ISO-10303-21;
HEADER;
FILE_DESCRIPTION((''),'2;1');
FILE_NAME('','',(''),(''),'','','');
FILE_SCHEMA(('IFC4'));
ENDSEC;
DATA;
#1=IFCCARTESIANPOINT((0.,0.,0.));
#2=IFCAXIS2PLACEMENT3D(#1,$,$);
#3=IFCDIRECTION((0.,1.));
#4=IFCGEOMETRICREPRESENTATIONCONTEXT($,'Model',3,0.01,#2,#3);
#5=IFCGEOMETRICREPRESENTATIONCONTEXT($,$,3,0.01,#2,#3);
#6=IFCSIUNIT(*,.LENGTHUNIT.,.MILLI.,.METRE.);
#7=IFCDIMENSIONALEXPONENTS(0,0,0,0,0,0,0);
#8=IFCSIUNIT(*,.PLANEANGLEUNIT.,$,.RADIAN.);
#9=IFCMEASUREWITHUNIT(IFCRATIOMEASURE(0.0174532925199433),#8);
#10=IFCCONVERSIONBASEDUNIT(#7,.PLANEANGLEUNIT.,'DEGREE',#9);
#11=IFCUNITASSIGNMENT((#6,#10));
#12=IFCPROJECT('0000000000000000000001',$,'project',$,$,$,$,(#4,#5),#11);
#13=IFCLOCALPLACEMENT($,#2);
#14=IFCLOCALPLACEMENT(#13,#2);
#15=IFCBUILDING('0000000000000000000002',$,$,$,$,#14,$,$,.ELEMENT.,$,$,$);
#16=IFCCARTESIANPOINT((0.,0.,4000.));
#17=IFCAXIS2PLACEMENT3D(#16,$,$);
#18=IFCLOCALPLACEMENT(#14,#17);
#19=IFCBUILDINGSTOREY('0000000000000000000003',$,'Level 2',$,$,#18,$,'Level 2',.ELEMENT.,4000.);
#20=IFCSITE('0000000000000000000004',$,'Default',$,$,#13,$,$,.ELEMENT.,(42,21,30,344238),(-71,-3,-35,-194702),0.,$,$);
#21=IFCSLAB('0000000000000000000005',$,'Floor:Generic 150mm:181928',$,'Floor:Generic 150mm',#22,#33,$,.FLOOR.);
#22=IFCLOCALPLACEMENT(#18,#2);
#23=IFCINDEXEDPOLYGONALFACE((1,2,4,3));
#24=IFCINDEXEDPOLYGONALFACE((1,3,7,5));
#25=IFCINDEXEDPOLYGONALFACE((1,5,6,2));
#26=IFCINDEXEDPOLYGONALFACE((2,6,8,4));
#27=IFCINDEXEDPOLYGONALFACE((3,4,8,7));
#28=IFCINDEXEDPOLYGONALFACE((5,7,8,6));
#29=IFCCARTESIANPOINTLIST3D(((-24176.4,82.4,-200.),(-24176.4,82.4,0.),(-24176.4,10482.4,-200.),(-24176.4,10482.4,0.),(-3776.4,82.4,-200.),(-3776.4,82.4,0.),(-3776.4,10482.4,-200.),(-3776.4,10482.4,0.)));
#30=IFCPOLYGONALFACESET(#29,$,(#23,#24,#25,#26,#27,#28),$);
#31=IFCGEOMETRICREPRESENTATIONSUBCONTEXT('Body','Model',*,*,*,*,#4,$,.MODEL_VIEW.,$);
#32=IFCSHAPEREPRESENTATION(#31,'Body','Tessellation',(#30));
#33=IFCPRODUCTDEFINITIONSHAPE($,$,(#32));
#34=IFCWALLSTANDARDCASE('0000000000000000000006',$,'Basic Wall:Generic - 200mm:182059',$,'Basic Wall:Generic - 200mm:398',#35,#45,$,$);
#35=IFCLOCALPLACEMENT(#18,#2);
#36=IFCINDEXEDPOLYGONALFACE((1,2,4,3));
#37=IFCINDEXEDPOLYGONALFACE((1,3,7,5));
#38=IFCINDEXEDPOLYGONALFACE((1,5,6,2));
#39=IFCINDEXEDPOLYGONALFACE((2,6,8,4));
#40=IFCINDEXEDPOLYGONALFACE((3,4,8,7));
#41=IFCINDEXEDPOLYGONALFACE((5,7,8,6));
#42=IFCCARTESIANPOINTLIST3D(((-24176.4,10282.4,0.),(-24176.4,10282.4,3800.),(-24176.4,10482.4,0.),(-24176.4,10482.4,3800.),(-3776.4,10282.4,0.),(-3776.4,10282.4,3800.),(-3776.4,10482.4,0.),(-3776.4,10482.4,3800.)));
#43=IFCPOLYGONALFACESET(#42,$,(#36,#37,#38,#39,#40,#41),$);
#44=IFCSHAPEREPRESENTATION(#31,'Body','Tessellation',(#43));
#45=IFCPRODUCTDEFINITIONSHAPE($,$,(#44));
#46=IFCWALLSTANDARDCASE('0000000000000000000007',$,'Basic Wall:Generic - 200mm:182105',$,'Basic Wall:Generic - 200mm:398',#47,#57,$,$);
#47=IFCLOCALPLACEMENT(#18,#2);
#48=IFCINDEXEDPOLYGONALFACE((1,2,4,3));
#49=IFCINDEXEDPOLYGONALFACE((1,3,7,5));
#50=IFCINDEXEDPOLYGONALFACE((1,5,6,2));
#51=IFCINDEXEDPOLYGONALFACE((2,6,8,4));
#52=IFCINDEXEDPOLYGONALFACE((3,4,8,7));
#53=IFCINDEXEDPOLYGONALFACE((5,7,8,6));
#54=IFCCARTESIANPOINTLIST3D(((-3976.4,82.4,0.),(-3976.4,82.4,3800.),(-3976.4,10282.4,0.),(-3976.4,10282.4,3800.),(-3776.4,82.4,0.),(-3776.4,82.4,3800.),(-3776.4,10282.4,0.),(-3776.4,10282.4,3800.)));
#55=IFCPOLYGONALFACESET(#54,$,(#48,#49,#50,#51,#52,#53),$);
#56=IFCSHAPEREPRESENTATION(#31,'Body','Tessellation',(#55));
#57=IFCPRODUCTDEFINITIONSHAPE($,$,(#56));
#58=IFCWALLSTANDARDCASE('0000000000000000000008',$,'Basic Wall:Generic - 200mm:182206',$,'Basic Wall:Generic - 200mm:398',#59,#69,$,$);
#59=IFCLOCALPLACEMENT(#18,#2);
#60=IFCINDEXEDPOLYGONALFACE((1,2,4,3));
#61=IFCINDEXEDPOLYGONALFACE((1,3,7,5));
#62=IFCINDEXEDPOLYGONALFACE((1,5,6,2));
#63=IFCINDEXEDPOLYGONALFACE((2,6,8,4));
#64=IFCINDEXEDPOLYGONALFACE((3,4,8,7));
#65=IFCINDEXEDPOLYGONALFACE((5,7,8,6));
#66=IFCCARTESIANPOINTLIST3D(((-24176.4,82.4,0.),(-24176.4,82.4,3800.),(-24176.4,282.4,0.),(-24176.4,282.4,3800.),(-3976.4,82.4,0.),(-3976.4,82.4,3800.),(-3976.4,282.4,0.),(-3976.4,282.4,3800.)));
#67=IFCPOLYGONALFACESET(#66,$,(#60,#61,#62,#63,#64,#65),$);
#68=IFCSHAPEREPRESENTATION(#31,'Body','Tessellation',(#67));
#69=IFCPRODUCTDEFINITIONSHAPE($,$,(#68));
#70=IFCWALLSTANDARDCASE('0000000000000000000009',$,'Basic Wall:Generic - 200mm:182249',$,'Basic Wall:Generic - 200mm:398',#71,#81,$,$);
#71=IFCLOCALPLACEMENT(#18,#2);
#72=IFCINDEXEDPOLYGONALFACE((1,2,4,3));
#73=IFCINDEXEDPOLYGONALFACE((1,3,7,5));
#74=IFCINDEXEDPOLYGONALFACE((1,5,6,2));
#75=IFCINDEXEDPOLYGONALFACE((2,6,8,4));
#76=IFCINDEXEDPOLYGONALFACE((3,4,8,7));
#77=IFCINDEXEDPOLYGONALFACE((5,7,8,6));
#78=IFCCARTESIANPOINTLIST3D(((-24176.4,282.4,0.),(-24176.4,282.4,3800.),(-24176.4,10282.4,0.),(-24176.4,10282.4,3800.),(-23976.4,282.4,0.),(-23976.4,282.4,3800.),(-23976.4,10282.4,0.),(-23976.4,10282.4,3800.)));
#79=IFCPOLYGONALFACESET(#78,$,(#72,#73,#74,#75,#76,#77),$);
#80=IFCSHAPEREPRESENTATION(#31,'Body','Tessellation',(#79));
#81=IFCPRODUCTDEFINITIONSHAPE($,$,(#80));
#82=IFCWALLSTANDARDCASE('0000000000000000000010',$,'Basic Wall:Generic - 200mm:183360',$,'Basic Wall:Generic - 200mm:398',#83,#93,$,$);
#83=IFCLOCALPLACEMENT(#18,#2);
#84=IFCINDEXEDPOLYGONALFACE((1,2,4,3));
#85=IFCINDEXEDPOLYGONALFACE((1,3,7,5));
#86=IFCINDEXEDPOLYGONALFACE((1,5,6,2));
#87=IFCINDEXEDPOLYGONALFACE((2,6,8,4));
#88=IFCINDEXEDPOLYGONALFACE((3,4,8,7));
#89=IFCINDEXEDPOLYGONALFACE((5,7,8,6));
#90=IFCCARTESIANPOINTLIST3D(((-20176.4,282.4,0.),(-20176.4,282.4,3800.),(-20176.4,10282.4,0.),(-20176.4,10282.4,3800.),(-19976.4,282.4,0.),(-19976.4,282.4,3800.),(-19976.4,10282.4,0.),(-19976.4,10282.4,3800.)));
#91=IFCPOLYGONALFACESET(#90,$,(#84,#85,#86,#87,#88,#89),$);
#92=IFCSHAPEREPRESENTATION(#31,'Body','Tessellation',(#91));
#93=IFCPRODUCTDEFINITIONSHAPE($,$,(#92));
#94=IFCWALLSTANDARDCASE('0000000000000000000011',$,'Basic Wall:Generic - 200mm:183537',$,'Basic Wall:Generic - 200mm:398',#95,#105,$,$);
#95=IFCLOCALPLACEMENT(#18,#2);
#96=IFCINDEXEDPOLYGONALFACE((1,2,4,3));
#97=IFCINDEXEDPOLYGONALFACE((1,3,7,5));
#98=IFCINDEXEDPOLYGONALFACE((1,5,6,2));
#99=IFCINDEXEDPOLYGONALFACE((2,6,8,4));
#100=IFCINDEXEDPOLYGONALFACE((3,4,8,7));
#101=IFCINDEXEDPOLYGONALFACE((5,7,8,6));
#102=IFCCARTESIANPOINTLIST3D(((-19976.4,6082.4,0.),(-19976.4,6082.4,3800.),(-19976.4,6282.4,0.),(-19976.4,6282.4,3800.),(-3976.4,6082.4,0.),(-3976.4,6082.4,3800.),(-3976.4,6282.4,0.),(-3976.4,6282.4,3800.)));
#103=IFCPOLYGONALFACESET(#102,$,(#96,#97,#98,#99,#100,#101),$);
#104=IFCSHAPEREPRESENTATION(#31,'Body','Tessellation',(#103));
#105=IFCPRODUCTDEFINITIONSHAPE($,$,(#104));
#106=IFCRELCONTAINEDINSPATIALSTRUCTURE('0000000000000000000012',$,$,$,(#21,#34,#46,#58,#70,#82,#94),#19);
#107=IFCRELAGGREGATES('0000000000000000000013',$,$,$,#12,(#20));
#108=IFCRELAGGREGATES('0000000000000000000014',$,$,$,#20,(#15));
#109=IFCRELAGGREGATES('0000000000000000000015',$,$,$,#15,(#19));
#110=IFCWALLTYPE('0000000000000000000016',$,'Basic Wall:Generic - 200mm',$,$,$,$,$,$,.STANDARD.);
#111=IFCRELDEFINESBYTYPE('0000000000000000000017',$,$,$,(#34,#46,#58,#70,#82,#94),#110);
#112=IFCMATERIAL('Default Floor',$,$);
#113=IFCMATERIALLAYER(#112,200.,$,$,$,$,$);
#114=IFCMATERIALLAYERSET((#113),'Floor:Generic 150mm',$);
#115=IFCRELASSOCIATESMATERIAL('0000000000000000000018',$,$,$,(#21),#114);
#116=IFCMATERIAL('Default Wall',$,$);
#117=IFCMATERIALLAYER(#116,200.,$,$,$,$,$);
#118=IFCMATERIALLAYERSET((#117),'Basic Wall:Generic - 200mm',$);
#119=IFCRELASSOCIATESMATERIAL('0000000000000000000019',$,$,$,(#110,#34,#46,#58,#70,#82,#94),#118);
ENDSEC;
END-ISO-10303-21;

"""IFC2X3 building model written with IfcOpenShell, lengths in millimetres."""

from ifc_helpers import new_model, entity, si_unit, converted_unit, direction, frame, frame_2d, origin, origin_2d_with_axis, place, context, subcontext, project, spatial, rectangle, extrude, material, layer, layer_set, layer_usage, type_object, element, save


model = new_model("IFC2X3")

# Units and contexts
model_context = context("Model", 3, precision=0.01, world=origin(), true_north=direction((0.0, 1.0)))
context_of_model = context(None, 3, precision=0.01, world=origin(), true_north=direction((0.0, 1.0)))
body_context = subcontext(model_context, "Body", "Model", "MODEL_VIEW")
ifc_project = project(units=[si_unit("LENGTHUNIT", "METRE", prefix="MILLI"), converted_unit("PLANEANGLEUNIT", "DEGREE", entity("IfcRatioMeasure", 0.0174532925199433), si_unit("PLANEANGLEUNIT", "RADIAN"), dimensions=[0, 0, 0, 0, 0, 0, 0])], contexts=[model_context, context_of_model])

# Site, building, storey
site_placement = place(None, origin())
site = spatial("IfcSite", under=ifc_project, at=site_placement, Name="Default", CompositionType="ELEMENT", RefLatitude=(42, 21, 30, 344238), RefLongitude=(-71, -3, -35, -194702), RefElevation=0.0)
building_placement = place(site_placement, origin())
building = spatial("IfcBuilding", under=site, at=building_placement, CompositionType="ELEMENT")
storey_placement = place(building_placement, frame((0.0, 0.0, 4000.0)))
storey = spatial("IfcBuildingStorey", under=building, at=storey_placement, Name="Level 2", LongName="Level 2", CompositionType="ELEMENT", Elevation=4000.0)

# Slab
ifc_material_1 = material(Name="Default Floor")
ifc_layer_1 = layer(ifc_material_1, 200.0)
ifc_layer_set_1 = layer_set([ifc_layer_1], Name="Floor:Generic 150mm")
ifc_layer_usage_1 = layer_usage(ifc_layer_set_1, "AXIS3", "POSITIVE", 0.0)
slab_placement = place(storey_placement, origin())
element("IfcSlab", 1, at=slab_placement, inside=storey, material=ifc_layer_usage_1, Name="Floor:Generic 150mm:181928", ObjectType="Floor:Generic 150mm", PredefinedType="FLOOR", context=body_context, shape_type="SweptSolid", body=[
    extrude(rectangle(XDim=10400.0, YDim=20400.0, at=origin_2d_with_axis()), frame((-13976.4, 5282.4, 0.0), z_axis=(0.0, 0.0, -1.0), x_axis=(0.0, 1.0, 0.0)), (0.0, 0.0, 1.0), 200.0),
])

# Walls
ifc_material_2 = material(Name="Default Wall")
ifc_layer_2 = layer(ifc_material_2, 200.0)
ifc_layer_set_2 = layer_set([ifc_layer_2], Name="Basic Wall:Generic - 200mm")
ifc_layer_usage_2 = layer_usage(ifc_layer_set_2, "AXIS2", "NEGATIVE", 100.0)
wall_type = type_object("IfcWallType", Name="Basic Wall:Generic - 200mm", PredefinedType="STANDARD", material=ifc_layer_set_2)
wall_1_placement = place(storey_placement, frame((-24176.4, 10382.4, 0.0)))
element("IfcWallStandardCase", 2, at=wall_1_placement, inside=storey, type_object=wall_type, material=ifc_layer_usage_2, Name="Basic Wall:Generic - 200mm:182059", ObjectType="Basic Wall:Generic - 200mm:398", context=body_context, shape_type="SweptSolid", body=[
    extrude(rectangle(XDim=20400.0, YDim=200.0, at=frame_2d((10200.0, 0.0), x_axis=(-1.0, 0.0))), origin(), (0.0, 0.0, 1.0), 3800.0),
])
ifc_layer_usage_3 = layer_usage(ifc_layer_set_2, "AXIS2", "NEGATIVE", 100.0)
wall_2_placement = place(storey_placement, frame((-3876.4, 10282.4, 0.0), z_axis=(0.0, 0.0, 1.0), x_axis=(0.0, -1.0, 0.0)))
element("IfcWallStandardCase", 3, at=wall_2_placement, inside=storey, type_object=wall_type, material=ifc_layer_usage_3, Name="Basic Wall:Generic - 200mm:182105", ObjectType="Basic Wall:Generic - 200mm:398", context=body_context, shape_type="SweptSolid", body=[
    extrude(rectangle(XDim=10200.0, YDim=200.0, at=frame_2d((5100.0, 0.0), x_axis=(-1.0, 0.0))), origin(), (0.0, 0.0, 1.0), 3800.0),
])
ifc_layer_usage_4 = layer_usage(ifc_layer_set_2, "AXIS2", "NEGATIVE", 100.0)
wall_3_placement = place(storey_placement, frame((-3976.4, 182.4, 0.0), z_axis=(0.0, 0.0, 1.0), x_axis=(-1.0, 0.0, 0.0)))
element("IfcWallStandardCase", 4, at=wall_3_placement, inside=storey, type_object=wall_type, material=ifc_layer_usage_4, Name="Basic Wall:Generic - 200mm:182206", ObjectType="Basic Wall:Generic - 200mm:398", context=body_context, shape_type="SweptSolid", body=[
    extrude(rectangle(XDim=20200.0, YDim=200.0, at=frame_2d((10100.0, 0.0), x_axis=(-1.0, 0.0))), origin(), (0.0, 0.0, 1.0), 3800.0),
])
ifc_layer_usage_5 = layer_usage(ifc_layer_set_2, "AXIS2", "NEGATIVE", 100.0)
wall_4_placement = place(storey_placement, frame((-24076.4, 282.4, 0.0), z_axis=(0.0, 0.0, 1.0), x_axis=(0.0, 1.0, 0.0)))
element("IfcWallStandardCase", 5, at=wall_4_placement, inside=storey, type_object=wall_type, material=ifc_layer_usage_5, Name="Basic Wall:Generic - 200mm:182249", ObjectType="Basic Wall:Generic - 200mm:398", context=body_context, shape_type="SweptSolid", body=[
    extrude(rectangle(XDim=10000.0, YDim=200.0, at=frame_2d((5000.0, 0.0), x_axis=(-1.0, 0.0))), origin(), (0.0, 0.0, 1.0), 3800.0),
])
ifc_layer_usage_6 = layer_usage(ifc_layer_set_2, "AXIS2", "NEGATIVE", 100.0)
wall_5_placement = place(storey_placement, frame((-20076.4, 10282.4, 0.0), z_axis=(0.0, 0.0, 1.0), x_axis=(0.0, -1.0, 0.0)))
element("IfcWallStandardCase", 6, at=wall_5_placement, inside=storey, type_object=wall_type, material=ifc_layer_usage_6, Name="Basic Wall:Generic - 200mm:183360", ObjectType="Basic Wall:Generic - 200mm:398", context=body_context, shape_type="SweptSolid", body=[
    extrude(rectangle(XDim=10000.0, YDim=200.0, at=frame_2d((5000.0, 0.0), x_axis=(-1.0, 0.0))), origin(), (0.0, 0.0, 1.0), 3800.0),
])
ifc_layer_usage_7 = layer_usage(ifc_layer_set_2, "AXIS2", "NEGATIVE", 100.0)
wall_6_placement = place(storey_placement, frame((-19976.4, 6182.4, 0.0)))
element("IfcWallStandardCase", 7, at=wall_6_placement, inside=storey, type_object=wall_type, material=ifc_layer_usage_7, Name="Basic Wall:Generic - 200mm:183537", ObjectType="Basic Wall:Generic - 200mm:398", context=body_context, shape_type="SweptSolid", body=[
    extrude(rectangle(XDim=16000.0, YDim=200.0, at=frame_2d((8000.0, 0.0), x_axis=(-1.0, 0.0))), origin(), (0.0, 0.0, 1.0), 3800.0),
])

save(model, "model.ifc")
